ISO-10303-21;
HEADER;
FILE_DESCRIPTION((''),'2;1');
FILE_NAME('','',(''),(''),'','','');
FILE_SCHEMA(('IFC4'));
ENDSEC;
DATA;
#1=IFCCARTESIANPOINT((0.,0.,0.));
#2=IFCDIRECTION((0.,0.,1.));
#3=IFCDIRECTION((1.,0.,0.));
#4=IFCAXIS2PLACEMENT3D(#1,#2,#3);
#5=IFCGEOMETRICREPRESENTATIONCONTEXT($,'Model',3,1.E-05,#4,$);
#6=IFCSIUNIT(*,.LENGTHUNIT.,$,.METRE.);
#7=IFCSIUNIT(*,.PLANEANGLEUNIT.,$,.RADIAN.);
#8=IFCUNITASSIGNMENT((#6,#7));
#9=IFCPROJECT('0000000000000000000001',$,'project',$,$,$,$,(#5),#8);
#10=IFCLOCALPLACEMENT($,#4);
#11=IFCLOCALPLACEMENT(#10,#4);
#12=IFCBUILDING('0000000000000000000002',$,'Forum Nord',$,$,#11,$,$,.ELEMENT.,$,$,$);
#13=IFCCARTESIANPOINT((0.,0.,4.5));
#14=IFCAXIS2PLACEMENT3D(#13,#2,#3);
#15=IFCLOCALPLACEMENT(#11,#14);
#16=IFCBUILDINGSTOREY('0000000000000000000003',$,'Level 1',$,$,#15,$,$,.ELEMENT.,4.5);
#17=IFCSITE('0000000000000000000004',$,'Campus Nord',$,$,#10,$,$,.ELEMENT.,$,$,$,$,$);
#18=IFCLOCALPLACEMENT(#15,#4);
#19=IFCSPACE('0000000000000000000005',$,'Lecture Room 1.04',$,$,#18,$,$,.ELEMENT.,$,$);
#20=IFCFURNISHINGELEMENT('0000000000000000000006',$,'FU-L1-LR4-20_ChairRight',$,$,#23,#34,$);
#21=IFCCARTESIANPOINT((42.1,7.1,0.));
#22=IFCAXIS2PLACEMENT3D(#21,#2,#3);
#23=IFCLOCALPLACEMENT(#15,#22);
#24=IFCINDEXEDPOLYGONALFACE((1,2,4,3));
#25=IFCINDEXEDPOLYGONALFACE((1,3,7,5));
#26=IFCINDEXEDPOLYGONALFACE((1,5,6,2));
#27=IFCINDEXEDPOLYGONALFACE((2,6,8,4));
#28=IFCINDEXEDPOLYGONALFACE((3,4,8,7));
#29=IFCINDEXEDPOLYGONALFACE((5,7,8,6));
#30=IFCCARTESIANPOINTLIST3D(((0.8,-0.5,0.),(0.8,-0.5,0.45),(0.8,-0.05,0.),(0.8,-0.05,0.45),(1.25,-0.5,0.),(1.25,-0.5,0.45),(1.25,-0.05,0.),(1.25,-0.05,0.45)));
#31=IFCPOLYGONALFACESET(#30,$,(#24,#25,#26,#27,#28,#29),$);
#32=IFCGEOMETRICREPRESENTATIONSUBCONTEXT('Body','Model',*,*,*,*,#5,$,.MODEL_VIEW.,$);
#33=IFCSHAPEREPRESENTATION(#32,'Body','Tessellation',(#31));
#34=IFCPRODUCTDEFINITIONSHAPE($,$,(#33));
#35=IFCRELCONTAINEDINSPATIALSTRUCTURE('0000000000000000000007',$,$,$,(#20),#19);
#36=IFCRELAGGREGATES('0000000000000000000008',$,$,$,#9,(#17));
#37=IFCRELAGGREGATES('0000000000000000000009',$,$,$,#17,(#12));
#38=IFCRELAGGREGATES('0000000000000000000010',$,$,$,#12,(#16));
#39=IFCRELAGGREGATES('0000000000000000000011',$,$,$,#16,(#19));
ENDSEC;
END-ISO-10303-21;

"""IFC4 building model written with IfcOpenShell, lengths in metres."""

from ifc_helpers import new_model, si_unit, frame, frame_2d, origin_with_axes, place, context, subcontext, project, spatial, rectangle, extrude, element, save


model = new_model("IFC4")

# Units and contexts
model_context = context("Model", 3, precision=1e-05, world=origin_with_axes())
body_context = subcontext(model_context, "Body", "Model", "MODEL_VIEW")
ifc_project = project(units=[si_unit("LENGTHUNIT", "METRE"), si_unit("PLANEANGLEUNIT", "RADIAN")], contexts=[model_context])

# Site, building, storey
site_placement = place(None, origin_with_axes())
site = spatial("IfcSite", under=ifc_project, at=site_placement, Name="Campus Nord", CompositionType="ELEMENT")
building_placement = place(site_placement, origin_with_axes())
building = spatial("IfcBuilding", under=site, at=building_placement, Name="Forum Nord", CompositionType="ELEMENT")
storey_placement = place(building_placement, frame((0.0, 0.0, 4.5), z_axis=(0.0, 0.0, 1.0), x_axis=(1.0, 0.0, 0.0)))
storey = spatial("IfcBuildingStorey", under=building, at=storey_placement, Name="Level 1", CompositionType="ELEMENT", Elevation=4.5)

# Shared definitions
space_placement = place(storey_placement, origin_with_axes())
space = spatial("IfcSpace", under=storey, at=space_placement, Name="Lecture Room 1.04", CompositionType="ELEMENT")

# Furnishing element
furnishing_1_placement = place(storey_placement, frame((42.1, 7.1, 0.0), z_axis=(0.0, 0.0, 1.0), x_axis=(1.0, 0.0, 0.0)))
element("IfcFurnishingElement", 1, at=furnishing_1_placement, inside=space, Name="FU-L1-LR4-20_ChairRight", context=body_context, shape_type="SweptSolid", body=[
    extrude(rectangle(XDim=0.45, YDim=0.45, at=frame_2d((1.025, -0.275), x_axis=(1.0, 0.0))), origin_with_axes(), (0.0, 0.0, 1.0), 0.45),
])

save(model, "model.ifc")
